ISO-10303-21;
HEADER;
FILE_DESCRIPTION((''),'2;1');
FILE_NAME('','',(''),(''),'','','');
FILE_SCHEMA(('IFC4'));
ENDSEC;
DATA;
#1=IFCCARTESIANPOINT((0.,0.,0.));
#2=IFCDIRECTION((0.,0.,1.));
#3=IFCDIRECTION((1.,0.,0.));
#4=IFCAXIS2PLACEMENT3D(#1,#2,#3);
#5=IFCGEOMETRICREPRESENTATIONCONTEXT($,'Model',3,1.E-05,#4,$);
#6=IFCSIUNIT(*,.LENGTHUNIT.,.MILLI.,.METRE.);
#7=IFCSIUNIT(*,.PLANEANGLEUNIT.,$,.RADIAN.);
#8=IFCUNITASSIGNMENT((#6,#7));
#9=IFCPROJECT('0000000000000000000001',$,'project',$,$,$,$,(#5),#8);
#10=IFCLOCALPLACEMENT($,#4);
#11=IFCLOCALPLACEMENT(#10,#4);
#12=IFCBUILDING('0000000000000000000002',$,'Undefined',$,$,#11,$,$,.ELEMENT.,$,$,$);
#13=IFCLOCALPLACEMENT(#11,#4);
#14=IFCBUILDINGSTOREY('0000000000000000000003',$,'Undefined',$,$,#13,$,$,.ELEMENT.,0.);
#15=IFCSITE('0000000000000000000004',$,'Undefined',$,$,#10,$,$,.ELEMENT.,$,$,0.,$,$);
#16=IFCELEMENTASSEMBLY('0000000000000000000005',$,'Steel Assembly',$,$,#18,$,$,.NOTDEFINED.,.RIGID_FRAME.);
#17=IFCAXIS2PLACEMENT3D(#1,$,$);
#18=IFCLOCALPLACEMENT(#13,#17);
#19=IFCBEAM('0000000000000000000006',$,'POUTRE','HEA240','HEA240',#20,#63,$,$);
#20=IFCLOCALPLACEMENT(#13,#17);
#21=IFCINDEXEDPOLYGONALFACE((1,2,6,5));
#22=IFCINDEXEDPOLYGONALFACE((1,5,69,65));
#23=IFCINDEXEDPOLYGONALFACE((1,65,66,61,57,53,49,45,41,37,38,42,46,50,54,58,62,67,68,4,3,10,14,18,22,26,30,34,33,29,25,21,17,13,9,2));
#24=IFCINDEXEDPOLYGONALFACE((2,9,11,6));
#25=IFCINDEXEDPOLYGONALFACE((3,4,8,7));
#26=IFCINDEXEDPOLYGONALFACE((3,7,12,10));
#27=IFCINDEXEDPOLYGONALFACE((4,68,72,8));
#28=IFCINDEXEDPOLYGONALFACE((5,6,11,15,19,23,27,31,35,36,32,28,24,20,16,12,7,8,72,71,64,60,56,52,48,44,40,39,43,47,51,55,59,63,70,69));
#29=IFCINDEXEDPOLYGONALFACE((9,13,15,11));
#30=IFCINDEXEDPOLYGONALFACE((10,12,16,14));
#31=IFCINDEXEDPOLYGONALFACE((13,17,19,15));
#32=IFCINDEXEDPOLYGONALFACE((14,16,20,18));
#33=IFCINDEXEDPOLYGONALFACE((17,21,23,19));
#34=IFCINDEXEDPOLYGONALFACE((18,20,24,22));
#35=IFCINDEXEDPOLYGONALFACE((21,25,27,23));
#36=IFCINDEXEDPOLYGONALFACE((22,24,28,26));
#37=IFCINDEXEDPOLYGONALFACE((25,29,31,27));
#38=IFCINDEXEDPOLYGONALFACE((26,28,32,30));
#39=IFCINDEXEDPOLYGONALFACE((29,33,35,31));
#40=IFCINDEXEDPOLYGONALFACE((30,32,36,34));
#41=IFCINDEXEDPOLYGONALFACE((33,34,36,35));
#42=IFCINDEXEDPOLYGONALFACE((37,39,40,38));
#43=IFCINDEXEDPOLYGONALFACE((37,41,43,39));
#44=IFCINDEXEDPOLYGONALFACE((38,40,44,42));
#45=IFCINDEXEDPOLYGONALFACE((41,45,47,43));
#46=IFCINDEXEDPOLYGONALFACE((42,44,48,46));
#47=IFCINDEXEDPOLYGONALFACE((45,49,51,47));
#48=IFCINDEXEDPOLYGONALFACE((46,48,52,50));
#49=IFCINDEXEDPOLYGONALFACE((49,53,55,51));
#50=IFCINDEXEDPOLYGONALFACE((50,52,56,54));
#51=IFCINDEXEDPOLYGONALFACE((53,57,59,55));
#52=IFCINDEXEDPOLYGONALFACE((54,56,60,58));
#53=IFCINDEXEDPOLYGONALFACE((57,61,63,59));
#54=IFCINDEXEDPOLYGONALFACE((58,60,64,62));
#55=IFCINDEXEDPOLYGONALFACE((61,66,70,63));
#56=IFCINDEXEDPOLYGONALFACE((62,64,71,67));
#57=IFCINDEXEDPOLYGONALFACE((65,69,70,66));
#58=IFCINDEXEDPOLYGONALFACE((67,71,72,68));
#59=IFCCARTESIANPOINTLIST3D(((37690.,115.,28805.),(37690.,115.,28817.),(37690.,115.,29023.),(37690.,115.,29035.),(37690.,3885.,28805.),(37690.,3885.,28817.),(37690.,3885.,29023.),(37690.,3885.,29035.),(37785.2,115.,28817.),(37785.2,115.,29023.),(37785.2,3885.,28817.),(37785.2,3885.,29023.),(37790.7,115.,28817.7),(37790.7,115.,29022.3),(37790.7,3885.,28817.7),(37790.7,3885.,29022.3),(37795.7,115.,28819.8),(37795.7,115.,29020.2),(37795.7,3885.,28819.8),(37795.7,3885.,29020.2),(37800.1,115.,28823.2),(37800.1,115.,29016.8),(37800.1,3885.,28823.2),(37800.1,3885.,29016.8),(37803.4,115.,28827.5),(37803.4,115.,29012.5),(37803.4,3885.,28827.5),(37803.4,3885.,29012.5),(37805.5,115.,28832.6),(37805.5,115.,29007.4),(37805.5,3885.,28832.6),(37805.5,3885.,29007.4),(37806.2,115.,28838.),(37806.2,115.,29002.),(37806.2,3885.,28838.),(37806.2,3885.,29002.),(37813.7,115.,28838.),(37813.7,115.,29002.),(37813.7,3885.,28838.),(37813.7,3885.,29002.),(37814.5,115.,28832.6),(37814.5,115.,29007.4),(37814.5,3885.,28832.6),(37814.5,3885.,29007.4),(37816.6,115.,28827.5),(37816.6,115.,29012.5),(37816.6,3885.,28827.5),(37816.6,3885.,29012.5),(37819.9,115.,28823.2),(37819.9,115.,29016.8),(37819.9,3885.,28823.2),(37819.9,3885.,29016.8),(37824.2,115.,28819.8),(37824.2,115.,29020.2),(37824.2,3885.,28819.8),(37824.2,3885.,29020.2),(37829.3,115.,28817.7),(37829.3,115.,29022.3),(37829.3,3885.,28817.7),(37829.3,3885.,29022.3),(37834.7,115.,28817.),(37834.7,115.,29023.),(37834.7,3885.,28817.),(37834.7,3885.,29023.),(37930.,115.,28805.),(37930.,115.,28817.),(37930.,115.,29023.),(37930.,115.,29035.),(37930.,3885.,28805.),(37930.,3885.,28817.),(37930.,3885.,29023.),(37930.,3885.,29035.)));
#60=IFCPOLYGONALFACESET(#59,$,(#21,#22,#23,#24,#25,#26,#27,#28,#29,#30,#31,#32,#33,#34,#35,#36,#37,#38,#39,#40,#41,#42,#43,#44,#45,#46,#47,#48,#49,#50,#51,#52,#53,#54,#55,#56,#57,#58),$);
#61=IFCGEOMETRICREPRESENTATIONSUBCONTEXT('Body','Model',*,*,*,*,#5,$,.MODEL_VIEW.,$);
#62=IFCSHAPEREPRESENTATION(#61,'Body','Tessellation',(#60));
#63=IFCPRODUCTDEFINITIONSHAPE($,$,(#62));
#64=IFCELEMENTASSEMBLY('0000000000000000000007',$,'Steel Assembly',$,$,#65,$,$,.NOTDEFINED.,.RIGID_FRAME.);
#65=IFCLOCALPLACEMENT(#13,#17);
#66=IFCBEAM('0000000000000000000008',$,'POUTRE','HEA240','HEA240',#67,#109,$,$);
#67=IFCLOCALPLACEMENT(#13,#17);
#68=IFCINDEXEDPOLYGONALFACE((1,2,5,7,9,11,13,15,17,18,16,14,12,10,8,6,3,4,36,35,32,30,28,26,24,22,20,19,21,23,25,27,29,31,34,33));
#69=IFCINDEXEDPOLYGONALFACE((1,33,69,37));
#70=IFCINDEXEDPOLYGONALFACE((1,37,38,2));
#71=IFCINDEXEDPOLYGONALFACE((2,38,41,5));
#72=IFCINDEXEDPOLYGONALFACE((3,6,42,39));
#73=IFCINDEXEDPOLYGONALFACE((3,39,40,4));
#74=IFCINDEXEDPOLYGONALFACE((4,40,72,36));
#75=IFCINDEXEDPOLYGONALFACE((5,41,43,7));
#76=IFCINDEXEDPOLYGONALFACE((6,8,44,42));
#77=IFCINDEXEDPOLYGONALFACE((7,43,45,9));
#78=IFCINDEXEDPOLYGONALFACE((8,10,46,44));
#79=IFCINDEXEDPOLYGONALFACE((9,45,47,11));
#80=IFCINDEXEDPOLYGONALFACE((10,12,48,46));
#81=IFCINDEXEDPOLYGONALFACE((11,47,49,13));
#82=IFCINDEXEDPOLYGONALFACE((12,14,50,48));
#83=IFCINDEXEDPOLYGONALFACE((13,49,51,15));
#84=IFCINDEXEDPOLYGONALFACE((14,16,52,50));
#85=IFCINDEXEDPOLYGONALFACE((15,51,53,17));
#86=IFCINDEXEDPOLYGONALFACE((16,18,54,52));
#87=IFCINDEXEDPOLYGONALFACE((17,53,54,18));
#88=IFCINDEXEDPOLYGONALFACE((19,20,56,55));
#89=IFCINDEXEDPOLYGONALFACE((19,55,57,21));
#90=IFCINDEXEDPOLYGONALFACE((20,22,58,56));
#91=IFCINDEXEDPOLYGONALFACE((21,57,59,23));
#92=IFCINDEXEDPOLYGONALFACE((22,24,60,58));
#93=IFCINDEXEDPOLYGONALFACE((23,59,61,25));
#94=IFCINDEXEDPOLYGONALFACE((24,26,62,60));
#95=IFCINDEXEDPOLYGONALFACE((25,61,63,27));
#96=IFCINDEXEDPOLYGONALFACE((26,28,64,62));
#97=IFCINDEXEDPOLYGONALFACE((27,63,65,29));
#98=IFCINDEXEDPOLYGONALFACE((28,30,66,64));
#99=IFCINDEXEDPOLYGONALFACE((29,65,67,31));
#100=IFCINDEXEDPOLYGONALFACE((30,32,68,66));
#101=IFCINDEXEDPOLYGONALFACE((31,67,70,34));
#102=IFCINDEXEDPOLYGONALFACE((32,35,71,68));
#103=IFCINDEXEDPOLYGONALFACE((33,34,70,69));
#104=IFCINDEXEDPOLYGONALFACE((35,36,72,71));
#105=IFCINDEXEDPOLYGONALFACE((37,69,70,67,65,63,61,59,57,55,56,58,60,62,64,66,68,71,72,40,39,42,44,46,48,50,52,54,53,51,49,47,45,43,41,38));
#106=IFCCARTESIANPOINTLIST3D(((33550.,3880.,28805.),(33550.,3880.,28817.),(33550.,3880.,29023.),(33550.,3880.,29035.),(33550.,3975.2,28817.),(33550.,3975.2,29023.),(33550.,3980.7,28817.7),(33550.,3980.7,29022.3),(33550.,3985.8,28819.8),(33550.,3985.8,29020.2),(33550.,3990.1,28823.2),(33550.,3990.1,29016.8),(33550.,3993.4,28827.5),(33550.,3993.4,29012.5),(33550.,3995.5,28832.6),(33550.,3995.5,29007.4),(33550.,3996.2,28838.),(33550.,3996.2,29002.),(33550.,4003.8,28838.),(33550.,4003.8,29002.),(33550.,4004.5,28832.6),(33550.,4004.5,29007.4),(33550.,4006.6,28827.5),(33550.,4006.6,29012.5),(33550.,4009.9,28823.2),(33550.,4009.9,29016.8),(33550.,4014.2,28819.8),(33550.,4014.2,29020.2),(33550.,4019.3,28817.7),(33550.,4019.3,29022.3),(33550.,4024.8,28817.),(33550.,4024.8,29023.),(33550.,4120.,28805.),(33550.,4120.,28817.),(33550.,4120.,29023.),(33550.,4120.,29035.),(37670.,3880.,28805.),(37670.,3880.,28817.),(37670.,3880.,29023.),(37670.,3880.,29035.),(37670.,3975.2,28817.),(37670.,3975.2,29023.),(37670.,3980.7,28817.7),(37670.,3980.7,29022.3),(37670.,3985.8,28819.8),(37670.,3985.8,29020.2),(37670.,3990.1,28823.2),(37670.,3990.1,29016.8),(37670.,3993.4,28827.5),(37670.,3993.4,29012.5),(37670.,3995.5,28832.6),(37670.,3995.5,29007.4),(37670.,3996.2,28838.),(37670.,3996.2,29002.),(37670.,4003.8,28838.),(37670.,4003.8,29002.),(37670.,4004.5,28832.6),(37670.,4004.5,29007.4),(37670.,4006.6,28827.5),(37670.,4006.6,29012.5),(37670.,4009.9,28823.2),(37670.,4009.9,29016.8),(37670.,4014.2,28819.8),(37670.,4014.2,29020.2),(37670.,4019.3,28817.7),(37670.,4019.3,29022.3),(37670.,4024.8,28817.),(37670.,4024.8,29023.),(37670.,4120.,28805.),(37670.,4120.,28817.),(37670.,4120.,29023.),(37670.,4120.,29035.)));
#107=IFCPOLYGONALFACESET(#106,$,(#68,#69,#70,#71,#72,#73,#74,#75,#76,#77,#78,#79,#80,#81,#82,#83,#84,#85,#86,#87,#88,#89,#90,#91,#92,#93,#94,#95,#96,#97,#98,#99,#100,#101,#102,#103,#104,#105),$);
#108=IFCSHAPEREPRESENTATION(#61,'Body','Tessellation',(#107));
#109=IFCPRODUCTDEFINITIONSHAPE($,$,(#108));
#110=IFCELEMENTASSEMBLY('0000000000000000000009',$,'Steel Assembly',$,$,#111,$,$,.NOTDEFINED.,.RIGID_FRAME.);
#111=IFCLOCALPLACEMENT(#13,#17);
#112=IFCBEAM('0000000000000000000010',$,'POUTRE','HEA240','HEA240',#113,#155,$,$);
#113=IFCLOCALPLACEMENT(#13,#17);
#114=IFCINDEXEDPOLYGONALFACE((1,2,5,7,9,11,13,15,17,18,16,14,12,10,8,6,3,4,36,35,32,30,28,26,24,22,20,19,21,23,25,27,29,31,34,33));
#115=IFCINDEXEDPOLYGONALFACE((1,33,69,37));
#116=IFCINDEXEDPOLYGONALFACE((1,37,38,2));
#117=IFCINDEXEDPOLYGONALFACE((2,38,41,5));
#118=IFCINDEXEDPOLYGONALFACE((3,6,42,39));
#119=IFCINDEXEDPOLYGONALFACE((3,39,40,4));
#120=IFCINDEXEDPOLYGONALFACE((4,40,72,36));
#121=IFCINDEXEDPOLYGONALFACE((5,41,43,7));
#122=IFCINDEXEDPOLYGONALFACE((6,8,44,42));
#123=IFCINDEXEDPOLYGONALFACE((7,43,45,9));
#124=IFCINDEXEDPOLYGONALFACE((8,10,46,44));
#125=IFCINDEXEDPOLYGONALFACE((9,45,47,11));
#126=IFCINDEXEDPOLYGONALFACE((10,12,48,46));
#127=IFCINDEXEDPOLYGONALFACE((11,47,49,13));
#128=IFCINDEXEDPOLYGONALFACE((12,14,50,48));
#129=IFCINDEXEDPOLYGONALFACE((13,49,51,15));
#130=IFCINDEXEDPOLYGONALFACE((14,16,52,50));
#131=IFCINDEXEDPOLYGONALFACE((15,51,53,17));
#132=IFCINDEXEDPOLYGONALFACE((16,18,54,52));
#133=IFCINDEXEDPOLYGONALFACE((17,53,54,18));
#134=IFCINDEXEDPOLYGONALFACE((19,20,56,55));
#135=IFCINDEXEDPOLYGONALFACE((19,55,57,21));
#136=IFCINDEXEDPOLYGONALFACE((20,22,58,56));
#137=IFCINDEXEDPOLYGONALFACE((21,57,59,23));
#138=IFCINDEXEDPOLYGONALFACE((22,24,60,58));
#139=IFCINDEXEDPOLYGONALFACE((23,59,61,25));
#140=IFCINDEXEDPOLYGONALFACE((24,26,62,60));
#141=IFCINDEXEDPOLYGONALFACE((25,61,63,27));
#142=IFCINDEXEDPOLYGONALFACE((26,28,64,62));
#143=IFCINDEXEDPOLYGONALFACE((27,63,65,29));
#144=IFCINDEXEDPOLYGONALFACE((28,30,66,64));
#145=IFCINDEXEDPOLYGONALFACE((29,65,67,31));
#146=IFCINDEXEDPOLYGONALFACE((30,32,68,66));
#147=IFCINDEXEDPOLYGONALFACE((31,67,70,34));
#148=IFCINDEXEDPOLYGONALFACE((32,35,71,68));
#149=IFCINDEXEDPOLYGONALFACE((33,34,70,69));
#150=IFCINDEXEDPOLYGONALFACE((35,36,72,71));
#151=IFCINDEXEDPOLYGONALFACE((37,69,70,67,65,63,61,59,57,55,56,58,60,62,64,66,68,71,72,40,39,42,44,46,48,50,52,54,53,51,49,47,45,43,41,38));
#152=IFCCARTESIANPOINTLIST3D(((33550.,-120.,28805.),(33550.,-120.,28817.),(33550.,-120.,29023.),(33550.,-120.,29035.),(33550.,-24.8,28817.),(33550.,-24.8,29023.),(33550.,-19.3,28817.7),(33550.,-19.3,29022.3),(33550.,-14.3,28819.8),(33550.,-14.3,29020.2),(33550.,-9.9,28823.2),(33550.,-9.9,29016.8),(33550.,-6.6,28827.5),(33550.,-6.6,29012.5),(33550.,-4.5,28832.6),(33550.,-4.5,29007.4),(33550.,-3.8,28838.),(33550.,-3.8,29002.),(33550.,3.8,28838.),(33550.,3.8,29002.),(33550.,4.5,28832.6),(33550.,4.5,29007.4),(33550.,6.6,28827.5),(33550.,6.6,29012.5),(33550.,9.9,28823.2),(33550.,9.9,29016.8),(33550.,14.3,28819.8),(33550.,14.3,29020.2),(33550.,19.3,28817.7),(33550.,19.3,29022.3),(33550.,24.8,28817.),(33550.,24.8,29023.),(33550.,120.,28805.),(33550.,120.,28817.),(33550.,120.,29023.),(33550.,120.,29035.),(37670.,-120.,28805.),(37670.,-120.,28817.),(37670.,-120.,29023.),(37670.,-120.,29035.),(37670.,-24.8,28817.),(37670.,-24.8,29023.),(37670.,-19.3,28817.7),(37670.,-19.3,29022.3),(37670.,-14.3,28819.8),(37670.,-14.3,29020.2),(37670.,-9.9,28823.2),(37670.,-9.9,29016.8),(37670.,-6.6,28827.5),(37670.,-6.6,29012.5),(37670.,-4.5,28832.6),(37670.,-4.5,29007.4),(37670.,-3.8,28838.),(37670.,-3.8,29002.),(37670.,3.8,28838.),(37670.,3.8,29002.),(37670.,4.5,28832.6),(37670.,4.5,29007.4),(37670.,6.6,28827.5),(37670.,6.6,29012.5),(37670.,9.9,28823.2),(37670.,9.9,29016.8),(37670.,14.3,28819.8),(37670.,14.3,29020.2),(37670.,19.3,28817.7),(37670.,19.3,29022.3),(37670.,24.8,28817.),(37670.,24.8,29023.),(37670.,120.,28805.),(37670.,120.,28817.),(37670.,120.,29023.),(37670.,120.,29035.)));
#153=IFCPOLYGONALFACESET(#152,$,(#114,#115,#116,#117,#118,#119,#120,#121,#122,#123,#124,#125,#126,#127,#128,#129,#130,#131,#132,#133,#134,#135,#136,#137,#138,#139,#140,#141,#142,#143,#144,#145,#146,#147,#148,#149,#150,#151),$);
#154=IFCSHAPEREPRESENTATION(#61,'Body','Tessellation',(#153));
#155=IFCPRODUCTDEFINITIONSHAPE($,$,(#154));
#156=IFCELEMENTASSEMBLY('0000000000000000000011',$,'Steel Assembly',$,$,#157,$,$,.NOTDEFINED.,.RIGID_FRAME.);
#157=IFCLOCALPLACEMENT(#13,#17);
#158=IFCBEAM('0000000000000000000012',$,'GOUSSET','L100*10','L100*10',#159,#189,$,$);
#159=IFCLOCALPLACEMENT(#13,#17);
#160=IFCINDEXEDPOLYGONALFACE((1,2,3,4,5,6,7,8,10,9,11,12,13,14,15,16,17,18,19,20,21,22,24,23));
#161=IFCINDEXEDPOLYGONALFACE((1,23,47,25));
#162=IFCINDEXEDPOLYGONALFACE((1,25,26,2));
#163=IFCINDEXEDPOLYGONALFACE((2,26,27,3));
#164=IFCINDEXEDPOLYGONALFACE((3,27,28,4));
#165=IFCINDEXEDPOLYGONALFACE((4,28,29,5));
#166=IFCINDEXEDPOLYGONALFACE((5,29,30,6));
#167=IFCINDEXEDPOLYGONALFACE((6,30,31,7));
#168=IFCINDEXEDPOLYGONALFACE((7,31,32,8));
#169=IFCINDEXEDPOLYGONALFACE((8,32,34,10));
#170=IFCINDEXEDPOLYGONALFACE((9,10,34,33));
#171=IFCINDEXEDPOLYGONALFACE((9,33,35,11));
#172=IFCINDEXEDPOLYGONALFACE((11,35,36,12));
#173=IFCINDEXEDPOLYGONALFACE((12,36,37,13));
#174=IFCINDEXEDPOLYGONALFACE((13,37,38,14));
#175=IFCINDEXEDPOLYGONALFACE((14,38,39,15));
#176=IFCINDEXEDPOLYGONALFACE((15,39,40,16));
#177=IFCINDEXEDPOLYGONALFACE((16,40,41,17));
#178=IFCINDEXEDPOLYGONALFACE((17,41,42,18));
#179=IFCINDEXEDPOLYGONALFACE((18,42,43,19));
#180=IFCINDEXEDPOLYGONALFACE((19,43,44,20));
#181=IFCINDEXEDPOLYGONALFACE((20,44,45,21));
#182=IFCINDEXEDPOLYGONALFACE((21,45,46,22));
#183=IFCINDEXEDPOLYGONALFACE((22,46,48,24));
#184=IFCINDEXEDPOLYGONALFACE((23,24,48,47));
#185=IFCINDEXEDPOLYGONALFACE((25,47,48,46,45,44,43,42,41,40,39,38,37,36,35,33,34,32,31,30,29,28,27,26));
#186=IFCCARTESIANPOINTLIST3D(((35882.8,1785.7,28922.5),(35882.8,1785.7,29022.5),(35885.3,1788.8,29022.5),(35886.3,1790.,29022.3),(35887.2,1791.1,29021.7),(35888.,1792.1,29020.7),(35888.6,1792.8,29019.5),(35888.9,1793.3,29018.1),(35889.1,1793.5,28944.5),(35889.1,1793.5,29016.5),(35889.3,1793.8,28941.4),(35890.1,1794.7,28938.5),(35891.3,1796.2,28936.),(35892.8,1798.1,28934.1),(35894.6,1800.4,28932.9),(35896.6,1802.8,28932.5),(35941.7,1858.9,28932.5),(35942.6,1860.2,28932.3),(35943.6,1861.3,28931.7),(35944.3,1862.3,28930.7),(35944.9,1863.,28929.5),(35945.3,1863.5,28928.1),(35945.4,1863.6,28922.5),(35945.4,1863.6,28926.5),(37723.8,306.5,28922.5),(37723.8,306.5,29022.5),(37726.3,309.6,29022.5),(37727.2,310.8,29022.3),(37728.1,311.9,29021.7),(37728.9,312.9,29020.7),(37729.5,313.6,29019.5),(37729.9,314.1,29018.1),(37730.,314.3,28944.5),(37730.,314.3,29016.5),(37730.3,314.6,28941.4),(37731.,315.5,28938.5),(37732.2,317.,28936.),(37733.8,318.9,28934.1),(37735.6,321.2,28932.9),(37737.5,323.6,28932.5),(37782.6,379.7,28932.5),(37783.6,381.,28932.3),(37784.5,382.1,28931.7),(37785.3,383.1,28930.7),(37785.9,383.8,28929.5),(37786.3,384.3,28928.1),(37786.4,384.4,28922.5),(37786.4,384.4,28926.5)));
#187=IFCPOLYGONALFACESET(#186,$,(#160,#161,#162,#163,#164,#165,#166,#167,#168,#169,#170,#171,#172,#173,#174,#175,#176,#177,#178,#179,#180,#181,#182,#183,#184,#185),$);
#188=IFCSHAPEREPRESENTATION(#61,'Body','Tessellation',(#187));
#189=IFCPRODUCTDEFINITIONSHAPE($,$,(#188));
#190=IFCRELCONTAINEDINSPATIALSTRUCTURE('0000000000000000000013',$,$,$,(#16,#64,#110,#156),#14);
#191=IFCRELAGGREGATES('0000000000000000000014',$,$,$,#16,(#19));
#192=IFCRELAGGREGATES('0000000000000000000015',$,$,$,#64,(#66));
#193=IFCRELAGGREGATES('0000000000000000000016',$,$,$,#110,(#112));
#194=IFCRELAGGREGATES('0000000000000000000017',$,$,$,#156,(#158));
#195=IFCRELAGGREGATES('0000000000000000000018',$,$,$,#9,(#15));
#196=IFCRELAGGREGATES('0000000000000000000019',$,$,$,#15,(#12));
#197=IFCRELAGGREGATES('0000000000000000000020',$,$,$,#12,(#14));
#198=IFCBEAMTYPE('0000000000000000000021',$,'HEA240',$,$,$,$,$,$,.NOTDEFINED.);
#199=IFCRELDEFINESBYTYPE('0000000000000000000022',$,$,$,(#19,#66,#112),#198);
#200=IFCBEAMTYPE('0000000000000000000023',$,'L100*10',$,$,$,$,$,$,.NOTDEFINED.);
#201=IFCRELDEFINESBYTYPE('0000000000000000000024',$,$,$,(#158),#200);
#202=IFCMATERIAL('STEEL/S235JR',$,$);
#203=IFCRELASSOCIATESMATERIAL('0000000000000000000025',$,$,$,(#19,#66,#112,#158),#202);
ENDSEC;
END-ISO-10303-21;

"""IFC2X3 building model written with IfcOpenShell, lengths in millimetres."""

from ifc_helpers import new_model, si_unit, frame, origin_with_axes, origin_2d_with_axis, place, context, subcontext, project, spatial, i_section, l_section, extrude, material, type_object, element, aggregate, save


model = new_model("IFC2X3")

# Units and contexts
model_context = context("Model", 3, precision=1e-05, world=origin_with_axes())
body_context = subcontext(model_context, "Body", "Model", "MODEL_VIEW")
ifc_project = project(units=[si_unit("LENGTHUNIT", "METRE", prefix="MILLI"), si_unit("PLANEANGLEUNIT", "RADIAN")], contexts=[model_context])

# Site, building, storey
site_placement = place(None, origin_with_axes())
site = spatial("IfcSite", under=ifc_project, at=site_placement, Name="Undefined", CompositionType="ELEMENT", RefElevation=0.0)
building_placement = place(site_placement, origin_with_axes())
building = spatial("IfcBuilding", under=site, at=building_placement, Name="Undefined", CompositionType="ELEMENT")
storey_placement = place(building_placement, origin_with_axes())
storey = spatial("IfcBuildingStorey", under=building, at=storey_placement, Name="Undefined", CompositionType="ELEMENT", Elevation=0.0)

# Element assemblies, beams
assembly_1_placement = place(storey_placement, origin_with_axes())
assembly_1 = element("IfcElementAssembly", 1, at=assembly_1_placement, inside=storey, Name="Steel Assembly", AssemblyPlace="NOTDEFINED", PredefinedType="RIGID_FRAME")
ifc_material_1 = material(Name="STEEL/S235JR")
beam_type_1 = type_object("IfcBeamType", Name="HEA240", PredefinedType="NOTDEFINED")
beam_1_placement = place(assembly_1_placement, frame((37810.0, 3885.0, 28920.0), z_axis=(0.0, 0.0, 1.0), x_axis=(0.0, -1.0, 0.0)))
beam_1 = element("IfcBeam", 2, at=beam_1_placement, type_object=beam_type_1, material=ifc_material_1, Name="POUTRE", Description="HEA240", ObjectType="HEA240", context=body_context, shape_type="SweptSolid", body=[
    extrude(i_section(OverallWidth=240.0, OverallDepth=230.0, WebThickness=7.5, FlangeThickness=12.0, FilletRadius=21.0, at=origin_2d_with_axis()), frame((3770.0, 0.0, 0.0), z_axis=(-1.0, 0.0, 0.0), x_axis=(0.0, -1.0, 0.0)), (0.0, 0.0, 1.0), 3770.0),
])
aggregate(assembly_1, [beam_1])
assembly_2_placement = place(storey_placement, origin_with_axes())
assembly_2 = element("IfcElementAssembly", 3, at=assembly_2_placement, inside=storey, Name="Steel Assembly", AssemblyPlace="NOTDEFINED", PredefinedType="RIGID_FRAME")
beam_2_placement = place(assembly_2_placement, frame((37689.1, 4000.0, 28920.0), z_axis=(0.0, 0.0, 1.0), x_axis=(-1.0, 0.0, 0.0)))
beam_2 = element("IfcBeam", 4, at=beam_2_placement, type_object=beam_type_1, material=ifc_material_1, Name="POUTRE", Description="HEA240", ObjectType="HEA240", context=body_context, shape_type="SweptSolid", body=[
    extrude(i_section(OverallWidth=240.0, OverallDepth=230.0, WebThickness=7.5, FlangeThickness=12.0, FilletRadius=21.0, at=origin_2d_with_axis()), frame((4139.1, 0.0, 0.0), z_axis=(-1.0, 0.0, 0.0), x_axis=(0.0, -1.0, 0.0)), (0.0, 0.0, 1.0), 4120.0),
])
aggregate(assembly_2, [beam_2])
assembly_3_placement = place(storey_placement, origin_with_axes())
assembly_3 = element("IfcElementAssembly", 5, at=assembly_3_placement, inside=storey, Name="Steel Assembly", AssemblyPlace="NOTDEFINED", PredefinedType="RIGID_FRAME")
beam_3_placement = place(assembly_3_placement, frame((37689.1, 0.0, 28920.0), z_axis=(0.0, 0.0, 1.0), x_axis=(-1.0, 0.0, 0.0)))
beam_3 = element("IfcBeam", 6, at=beam_3_placement, type_object=beam_type_1, material=ifc_material_1, Name="POUTRE", Description="HEA240", ObjectType="HEA240", context=body_context, shape_type="SweptSolid", body=[
    extrude(i_section(OverallWidth=240.0, OverallDepth=230.0, WebThickness=7.5, FlangeThickness=12.0, FilletRadius=21.0, at=origin_2d_with_axis()), frame((4139.1, 0.0, 0.0), z_axis=(-1.0, 0.0, 0.0), x_axis=(0.0, -1.0, 0.0)), (0.0, 0.0, 1.0), 4120.0),
])
aggregate(assembly_3, [beam_3])
assembly_4_placement = place(storey_placement, origin_with_axes())
assembly_4 = element("IfcElementAssembly", 7, at=assembly_4_placement, inside=storey, Name="Steel Assembly", AssemblyPlace="NOTDEFINED", PredefinedType="RIGID_FRAME")
beam_type_2 = type_object("IfcBeamType", Name="L100*10", PredefinedType="NOTDEFINED")
beam_4_placement = place(assembly_4_placement, frame((37755.1, 345.5, 28972.5), z_axis=(0.0, 0.0, 1.0), x_axis=(-0.779537, 0.626356, 0.0)))
beam_4 = element("IfcBeam", 8, at=beam_4_placement, type_object=beam_type_2, material=ifc_material_1, Name="GOUSSET", Description="L100*10", ObjectType="L100*10", context=body_context, shape_type="SweptSolid", body=[
    extrude(l_section(Depth=100.0, Width=100.0, Thickness=10.0, FilletRadius=12.0, EdgeRadius=6.0, at=origin_2d_with_axis()), frame((2361.6, 0.0, 0.0), z_axis=(-1.0, 0.0, 0.0), x_axis=(0.0, -1.0, 0.0)), (0.0, 0.0, 1.0), 2361.6),
])

aggregate(assembly_4, [beam_4])

save(model, "model.ifc")
